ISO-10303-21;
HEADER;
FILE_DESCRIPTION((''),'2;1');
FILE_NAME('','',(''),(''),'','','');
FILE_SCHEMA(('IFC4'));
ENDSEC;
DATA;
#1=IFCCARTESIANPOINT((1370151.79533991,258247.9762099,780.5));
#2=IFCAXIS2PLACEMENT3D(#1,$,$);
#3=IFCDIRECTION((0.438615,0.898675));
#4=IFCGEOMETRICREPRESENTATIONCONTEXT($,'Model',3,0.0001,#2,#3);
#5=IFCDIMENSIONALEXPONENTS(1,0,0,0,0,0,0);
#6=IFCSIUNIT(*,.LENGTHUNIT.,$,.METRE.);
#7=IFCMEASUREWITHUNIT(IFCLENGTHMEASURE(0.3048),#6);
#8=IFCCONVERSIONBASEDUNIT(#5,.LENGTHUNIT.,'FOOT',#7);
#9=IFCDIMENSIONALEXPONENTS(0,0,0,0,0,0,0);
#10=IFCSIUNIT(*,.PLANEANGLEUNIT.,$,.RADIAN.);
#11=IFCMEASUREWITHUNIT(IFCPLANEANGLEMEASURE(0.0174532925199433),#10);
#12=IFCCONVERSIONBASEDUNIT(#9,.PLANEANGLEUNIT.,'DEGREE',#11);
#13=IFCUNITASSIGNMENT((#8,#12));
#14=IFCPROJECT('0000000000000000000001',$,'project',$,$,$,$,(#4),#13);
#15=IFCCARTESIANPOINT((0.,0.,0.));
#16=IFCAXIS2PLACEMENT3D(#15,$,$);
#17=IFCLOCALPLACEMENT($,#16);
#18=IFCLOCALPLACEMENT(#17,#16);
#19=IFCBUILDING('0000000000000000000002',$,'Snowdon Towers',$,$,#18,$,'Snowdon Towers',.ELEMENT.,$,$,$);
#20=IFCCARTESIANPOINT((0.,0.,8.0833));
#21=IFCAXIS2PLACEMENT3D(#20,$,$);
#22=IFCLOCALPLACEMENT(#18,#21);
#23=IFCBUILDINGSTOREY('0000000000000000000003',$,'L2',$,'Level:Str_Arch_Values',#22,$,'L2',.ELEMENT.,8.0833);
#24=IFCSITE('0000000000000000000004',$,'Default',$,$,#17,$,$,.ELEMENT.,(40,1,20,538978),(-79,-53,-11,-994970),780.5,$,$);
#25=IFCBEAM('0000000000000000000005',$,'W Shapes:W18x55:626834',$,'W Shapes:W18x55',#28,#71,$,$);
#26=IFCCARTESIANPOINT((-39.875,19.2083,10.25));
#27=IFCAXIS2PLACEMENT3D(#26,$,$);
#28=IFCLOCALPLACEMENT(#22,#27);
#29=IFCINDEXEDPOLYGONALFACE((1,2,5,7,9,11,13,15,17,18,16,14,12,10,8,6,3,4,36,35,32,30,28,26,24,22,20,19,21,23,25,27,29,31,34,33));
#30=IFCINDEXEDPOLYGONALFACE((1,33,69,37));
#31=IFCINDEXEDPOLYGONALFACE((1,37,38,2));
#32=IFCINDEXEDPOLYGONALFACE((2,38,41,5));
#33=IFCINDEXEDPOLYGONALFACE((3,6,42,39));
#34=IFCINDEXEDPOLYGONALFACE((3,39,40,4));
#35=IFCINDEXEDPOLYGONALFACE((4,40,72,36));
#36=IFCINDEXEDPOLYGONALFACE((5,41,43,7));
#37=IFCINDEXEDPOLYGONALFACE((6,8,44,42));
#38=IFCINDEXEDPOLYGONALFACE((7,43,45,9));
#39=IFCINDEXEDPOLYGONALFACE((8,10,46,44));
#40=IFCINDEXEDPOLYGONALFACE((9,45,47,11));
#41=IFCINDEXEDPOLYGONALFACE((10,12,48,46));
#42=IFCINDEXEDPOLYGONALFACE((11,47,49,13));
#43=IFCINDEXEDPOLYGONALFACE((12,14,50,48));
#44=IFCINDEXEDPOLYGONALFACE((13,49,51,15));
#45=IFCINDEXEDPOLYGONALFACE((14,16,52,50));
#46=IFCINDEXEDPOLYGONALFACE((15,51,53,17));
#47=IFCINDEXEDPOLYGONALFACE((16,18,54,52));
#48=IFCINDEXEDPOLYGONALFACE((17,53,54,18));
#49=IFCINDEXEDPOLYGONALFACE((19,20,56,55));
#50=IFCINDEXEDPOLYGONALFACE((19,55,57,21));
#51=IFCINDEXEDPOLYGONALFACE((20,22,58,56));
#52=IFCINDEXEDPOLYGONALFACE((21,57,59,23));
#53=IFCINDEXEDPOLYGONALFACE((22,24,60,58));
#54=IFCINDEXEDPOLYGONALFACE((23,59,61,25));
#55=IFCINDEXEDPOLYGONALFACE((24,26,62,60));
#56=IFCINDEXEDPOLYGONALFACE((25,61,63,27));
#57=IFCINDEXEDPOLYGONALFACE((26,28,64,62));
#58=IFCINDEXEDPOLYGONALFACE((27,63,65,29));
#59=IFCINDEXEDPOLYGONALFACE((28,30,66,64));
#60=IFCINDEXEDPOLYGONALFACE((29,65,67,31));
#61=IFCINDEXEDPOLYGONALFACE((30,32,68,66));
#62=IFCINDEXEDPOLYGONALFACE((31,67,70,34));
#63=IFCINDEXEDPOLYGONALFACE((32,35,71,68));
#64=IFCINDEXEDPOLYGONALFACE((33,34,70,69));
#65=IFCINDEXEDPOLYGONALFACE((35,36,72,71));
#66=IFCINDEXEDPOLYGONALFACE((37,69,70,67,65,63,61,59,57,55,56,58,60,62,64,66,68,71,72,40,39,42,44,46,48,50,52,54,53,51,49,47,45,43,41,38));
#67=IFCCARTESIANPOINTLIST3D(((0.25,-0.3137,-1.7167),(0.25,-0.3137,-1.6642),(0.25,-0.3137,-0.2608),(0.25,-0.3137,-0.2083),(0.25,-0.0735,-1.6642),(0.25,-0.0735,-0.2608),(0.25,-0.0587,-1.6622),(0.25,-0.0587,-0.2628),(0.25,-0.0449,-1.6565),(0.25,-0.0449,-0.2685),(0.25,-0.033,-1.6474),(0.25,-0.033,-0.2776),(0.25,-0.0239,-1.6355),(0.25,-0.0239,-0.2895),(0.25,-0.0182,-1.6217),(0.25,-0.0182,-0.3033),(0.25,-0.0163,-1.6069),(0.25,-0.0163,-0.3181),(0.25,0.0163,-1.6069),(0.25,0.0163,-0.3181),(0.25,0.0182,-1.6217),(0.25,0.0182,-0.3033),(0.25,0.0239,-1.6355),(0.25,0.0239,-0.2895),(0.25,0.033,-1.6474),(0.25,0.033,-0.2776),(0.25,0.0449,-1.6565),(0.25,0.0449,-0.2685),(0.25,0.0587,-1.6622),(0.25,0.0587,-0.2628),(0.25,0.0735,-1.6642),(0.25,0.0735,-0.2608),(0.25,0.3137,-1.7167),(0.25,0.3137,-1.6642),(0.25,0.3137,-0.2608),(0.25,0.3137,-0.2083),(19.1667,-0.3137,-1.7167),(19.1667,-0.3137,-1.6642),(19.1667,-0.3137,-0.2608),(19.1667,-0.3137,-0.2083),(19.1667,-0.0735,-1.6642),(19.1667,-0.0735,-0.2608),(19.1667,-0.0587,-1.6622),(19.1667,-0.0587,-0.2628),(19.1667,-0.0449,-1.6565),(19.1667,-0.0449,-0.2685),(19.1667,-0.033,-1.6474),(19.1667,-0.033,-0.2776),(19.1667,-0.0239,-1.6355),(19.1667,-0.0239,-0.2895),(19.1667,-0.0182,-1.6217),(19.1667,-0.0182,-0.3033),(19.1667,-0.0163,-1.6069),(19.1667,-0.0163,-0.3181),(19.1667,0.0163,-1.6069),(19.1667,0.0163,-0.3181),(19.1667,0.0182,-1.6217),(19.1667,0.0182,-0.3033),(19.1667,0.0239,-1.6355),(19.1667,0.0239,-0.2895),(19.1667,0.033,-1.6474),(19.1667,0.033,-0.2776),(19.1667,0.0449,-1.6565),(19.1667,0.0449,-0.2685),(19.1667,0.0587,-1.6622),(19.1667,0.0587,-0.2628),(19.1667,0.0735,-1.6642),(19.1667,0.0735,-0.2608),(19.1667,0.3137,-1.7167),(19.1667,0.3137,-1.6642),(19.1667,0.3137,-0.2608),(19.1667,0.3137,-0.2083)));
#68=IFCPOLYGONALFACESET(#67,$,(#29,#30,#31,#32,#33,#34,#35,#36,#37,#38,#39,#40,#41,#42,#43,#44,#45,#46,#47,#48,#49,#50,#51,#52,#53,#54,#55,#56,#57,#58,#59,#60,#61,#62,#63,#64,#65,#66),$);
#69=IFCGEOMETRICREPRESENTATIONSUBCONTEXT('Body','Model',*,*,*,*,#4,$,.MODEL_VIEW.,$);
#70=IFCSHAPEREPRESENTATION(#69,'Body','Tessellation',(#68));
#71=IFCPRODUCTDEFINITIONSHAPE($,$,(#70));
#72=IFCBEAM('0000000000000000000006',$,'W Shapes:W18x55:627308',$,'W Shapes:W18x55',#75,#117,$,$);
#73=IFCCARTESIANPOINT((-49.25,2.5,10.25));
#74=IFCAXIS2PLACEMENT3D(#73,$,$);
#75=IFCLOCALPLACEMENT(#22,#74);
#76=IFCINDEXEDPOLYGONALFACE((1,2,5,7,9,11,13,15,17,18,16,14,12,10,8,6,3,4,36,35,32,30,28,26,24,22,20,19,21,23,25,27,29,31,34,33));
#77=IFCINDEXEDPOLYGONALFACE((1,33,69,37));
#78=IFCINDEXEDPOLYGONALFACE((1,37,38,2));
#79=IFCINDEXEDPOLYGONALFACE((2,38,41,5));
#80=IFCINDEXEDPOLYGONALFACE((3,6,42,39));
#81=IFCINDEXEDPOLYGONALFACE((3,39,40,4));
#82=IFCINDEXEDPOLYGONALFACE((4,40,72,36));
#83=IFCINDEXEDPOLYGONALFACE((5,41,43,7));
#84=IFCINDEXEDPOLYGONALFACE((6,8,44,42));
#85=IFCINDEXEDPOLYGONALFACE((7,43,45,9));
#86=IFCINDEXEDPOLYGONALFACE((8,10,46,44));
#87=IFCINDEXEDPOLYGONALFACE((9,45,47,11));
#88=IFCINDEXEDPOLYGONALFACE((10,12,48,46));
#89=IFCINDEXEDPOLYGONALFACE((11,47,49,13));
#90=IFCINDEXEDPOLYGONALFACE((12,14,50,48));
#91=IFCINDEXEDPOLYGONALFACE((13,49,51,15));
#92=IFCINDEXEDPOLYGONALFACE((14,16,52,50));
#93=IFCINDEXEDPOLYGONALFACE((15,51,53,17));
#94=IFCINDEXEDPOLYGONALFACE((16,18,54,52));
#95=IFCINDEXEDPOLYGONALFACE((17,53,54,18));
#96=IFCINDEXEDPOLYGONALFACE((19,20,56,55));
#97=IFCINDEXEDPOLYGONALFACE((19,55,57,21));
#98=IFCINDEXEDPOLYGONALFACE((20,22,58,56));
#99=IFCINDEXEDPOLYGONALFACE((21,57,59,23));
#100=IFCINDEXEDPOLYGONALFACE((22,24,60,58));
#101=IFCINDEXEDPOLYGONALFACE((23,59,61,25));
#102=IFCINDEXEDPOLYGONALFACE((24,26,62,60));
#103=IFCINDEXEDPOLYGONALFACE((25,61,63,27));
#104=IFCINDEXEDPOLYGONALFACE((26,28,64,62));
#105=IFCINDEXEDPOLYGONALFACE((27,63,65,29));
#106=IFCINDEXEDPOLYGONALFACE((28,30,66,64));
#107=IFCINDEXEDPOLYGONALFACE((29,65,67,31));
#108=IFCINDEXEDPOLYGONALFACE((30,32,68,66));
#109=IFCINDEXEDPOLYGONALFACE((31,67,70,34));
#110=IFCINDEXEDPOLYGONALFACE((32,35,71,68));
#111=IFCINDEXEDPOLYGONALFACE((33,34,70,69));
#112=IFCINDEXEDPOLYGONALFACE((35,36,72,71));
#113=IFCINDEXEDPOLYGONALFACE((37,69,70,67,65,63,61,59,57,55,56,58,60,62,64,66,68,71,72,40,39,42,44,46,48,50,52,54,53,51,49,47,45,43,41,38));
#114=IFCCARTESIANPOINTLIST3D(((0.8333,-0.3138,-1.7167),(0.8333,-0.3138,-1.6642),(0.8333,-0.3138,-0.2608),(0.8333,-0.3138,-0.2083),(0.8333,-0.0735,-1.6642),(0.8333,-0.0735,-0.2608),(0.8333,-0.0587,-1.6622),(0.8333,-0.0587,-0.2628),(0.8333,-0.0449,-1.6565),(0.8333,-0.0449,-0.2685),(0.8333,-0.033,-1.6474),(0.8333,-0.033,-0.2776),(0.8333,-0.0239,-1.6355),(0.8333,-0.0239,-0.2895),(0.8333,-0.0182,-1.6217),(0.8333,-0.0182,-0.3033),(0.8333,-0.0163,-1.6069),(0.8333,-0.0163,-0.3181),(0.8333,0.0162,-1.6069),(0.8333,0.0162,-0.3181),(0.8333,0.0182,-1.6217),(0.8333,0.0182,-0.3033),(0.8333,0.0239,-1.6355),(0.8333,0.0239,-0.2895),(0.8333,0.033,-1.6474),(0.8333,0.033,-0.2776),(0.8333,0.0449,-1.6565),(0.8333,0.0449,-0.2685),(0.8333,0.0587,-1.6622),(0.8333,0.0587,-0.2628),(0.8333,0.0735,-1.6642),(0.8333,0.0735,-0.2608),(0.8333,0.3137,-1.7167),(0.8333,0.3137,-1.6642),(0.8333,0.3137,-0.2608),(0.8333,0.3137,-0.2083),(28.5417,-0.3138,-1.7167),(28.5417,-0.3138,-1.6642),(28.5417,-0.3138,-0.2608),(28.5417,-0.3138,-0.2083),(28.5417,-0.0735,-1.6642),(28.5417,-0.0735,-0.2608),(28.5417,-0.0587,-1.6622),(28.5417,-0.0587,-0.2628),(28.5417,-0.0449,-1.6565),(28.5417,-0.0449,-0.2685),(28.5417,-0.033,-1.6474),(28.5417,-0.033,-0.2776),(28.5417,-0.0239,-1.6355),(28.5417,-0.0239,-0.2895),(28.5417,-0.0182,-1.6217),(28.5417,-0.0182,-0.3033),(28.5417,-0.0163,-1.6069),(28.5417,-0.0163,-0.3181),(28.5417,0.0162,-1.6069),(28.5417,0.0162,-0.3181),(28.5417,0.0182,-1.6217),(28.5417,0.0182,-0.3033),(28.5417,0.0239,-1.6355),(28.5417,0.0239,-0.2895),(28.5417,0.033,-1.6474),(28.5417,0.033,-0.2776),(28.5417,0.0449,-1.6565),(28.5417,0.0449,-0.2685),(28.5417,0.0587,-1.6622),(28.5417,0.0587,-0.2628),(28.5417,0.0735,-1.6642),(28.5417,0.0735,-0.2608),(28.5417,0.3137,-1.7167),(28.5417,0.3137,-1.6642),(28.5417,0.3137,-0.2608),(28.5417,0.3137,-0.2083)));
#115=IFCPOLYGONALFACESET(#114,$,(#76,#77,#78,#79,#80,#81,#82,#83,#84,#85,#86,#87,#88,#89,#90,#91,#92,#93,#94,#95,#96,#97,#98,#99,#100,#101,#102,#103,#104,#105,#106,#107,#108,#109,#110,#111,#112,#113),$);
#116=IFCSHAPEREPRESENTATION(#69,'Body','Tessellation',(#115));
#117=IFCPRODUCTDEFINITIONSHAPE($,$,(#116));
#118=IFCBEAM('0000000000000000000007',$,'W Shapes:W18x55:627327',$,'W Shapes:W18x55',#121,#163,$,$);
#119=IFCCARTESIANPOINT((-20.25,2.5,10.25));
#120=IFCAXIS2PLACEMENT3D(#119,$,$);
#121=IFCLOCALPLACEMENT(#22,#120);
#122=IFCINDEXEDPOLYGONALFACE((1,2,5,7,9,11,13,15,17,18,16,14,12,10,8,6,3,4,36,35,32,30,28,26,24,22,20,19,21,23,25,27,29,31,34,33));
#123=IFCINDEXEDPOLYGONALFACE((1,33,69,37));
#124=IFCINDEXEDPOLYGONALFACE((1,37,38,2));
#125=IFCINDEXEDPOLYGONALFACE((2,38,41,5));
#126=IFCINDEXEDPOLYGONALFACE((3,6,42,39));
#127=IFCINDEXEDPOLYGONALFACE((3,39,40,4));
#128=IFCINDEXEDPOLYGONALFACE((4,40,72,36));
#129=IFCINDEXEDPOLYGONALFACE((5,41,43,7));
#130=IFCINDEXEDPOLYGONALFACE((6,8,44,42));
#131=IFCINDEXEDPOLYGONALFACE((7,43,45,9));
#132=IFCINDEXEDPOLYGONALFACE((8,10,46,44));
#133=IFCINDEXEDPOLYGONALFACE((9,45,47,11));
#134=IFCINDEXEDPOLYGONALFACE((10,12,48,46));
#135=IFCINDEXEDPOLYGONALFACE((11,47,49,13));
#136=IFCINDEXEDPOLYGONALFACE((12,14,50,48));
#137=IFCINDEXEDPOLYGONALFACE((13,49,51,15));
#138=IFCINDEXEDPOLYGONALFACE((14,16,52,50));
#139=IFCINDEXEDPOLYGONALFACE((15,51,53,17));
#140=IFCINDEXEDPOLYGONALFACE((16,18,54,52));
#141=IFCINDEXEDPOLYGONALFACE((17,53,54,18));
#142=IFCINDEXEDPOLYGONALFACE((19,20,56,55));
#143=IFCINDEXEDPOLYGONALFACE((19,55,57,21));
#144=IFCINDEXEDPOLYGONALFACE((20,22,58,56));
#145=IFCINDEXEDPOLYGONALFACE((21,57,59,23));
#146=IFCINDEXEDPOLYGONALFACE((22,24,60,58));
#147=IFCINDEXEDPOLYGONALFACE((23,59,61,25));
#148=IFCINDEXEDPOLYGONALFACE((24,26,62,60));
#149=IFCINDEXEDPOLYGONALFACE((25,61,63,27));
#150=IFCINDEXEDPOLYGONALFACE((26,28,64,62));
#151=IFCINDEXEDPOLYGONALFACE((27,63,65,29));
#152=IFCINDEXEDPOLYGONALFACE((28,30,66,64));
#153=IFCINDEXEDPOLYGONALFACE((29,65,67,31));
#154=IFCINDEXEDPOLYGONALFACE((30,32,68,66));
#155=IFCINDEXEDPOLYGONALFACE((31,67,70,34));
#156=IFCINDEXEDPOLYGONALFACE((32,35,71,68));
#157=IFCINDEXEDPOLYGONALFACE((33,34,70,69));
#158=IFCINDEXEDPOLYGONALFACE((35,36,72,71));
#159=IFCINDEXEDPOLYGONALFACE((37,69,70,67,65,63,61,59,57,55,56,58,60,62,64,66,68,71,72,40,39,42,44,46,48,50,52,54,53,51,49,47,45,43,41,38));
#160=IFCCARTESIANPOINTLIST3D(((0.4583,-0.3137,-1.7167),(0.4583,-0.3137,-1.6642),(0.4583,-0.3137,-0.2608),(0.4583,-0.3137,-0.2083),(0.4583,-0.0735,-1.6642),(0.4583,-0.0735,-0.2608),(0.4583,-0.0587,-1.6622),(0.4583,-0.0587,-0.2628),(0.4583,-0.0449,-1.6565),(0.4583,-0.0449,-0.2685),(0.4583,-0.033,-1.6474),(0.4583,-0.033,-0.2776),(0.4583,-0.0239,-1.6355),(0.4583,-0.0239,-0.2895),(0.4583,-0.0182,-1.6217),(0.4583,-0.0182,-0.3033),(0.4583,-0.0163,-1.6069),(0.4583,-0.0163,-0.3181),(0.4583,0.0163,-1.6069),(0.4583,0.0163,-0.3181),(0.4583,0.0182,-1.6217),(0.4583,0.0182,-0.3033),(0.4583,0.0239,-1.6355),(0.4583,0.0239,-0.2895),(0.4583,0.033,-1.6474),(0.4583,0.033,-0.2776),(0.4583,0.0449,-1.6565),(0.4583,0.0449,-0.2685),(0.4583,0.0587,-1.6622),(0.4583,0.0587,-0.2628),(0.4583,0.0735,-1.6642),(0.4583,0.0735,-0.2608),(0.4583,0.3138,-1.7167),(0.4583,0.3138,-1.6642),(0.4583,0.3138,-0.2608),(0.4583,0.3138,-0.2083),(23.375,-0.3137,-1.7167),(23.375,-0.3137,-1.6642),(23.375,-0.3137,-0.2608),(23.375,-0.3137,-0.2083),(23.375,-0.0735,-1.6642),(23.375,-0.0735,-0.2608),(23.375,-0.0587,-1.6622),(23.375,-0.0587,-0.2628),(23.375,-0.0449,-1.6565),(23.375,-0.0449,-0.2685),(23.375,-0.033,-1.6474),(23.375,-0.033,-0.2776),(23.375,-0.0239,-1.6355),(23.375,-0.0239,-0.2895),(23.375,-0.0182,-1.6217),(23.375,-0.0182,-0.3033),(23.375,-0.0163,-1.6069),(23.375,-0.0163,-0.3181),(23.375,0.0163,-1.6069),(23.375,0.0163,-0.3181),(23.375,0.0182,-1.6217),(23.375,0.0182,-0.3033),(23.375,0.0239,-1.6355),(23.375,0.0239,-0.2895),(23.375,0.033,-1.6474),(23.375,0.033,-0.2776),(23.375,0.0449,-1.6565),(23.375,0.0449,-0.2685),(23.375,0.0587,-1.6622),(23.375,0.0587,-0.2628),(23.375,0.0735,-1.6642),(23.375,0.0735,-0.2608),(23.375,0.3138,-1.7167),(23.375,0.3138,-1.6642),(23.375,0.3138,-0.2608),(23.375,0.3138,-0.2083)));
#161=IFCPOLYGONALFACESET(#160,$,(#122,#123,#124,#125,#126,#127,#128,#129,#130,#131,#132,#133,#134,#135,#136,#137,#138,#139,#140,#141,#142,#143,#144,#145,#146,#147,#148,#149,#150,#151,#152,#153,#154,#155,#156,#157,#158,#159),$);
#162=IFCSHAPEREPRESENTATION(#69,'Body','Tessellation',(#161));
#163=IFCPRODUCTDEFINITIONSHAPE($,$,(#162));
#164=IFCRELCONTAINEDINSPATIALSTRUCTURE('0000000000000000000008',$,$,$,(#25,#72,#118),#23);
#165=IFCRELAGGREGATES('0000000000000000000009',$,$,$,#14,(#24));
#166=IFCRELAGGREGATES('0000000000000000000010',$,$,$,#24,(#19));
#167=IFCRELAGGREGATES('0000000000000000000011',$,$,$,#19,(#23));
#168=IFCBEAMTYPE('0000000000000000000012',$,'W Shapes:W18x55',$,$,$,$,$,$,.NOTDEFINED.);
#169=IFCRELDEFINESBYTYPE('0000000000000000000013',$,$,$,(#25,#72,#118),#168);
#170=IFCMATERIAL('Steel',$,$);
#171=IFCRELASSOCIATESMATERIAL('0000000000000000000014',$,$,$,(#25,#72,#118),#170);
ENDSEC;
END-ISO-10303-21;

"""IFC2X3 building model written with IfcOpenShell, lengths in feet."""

from ifc_helpers import new_model, entity, si_unit, converted_unit, direction, frame, frame_2d, origin, place, context, subcontext, project, spatial, i_section, extrude, material, type_object, element, save


model = new_model("IFC2X3")

# Units and contexts
model_context = context("Model", 3, precision=0.0001, world=frame((1370151.79533991, 258247.9762099, 780.5)), true_north=direction((0.438615, 0.898675)))
body_context = subcontext(model_context, "Body", "Model", "MODEL_VIEW")
ifc_project = project(units=[converted_unit("LENGTHUNIT", "FOOT", entity("IfcLengthMeasure", 0.3048), si_unit("LENGTHUNIT", "METRE"), dimensions=[1, 0, 0, 0, 0, 0, 0]), converted_unit("PLANEANGLEUNIT", "DEGREE", entity("IfcPlaneAngleMeasure", 0.0174532925199433), si_unit("PLANEANGLEUNIT", "RADIAN"), dimensions=[0, 0, 0, 0, 0, 0, 0])], contexts=[model_context])

# Site, building, storey
site_placement = place(None, origin())
site = spatial("IfcSite", under=ifc_project, at=site_placement, Name="Default", CompositionType="ELEMENT", RefLatitude=(40, 1, 20, 538978), RefLongitude=(-79, -53, -11, -994970), RefElevation=780.5)
building_placement = place(site_placement, origin())
building = spatial("IfcBuilding", under=site, at=building_placement, Name="Snowdon Towers", LongName="Snowdon Towers", CompositionType="ELEMENT")
storey_placement = place(building_placement, frame((0.0, 0.0, 8.0833)))
storey = spatial("IfcBuildingStorey", under=building, at=storey_placement, Name="L2", ObjectType="Level:Str_Arch_Values", LongName="L2", CompositionType="ELEMENT", Elevation=8.0833)

# Beams
ifc_material_1 = material(Name="Steel")
beam_type_1 = type_object("IfcBeamType", Name="W Shapes:W18x55", PredefinedType="NOTDEFINED")
beam_1_placement = place(storey_placement, frame((-39.875, 19.2083, 10.25)))
element("IfcBeam", 1, at=beam_1_placement, inside=storey, type_object=beam_type_1, material=ifc_material_1, Name="W Shapes:W18x55:626834", ObjectType="W Shapes:W18x55", context=body_context, shape_type="SweptSolid", body=[
    extrude(i_section(OverallWidth=0.6275, OverallDepth=1.5083, WebThickness=0.0325, FlangeThickness=0.0525, FilletRadius=0.0573, at=frame_2d((0.0, 0.0), x_axis=(0.0, 1.0))), frame((0.25, 0.0, -0.9625), z_axis=(1.0, 0.0, 0.0), x_axis=(0.0, 0.0, -1.0)), (0.0, 0.0, 1.0), 18.9167),
])
beam_2_placement = place(storey_placement, frame((-49.25, 2.5, 10.25)))
element("IfcBeam", 2, at=beam_2_placement, inside=storey, type_object=beam_type_1, material=ifc_material_1, Name="W Shapes:W18x55:627308", ObjectType="W Shapes:W18x55", context=body_context, shape_type="SweptSolid", body=[
    extrude(i_section(OverallWidth=0.6275, OverallDepth=1.5083, WebThickness=0.0325, FlangeThickness=0.0525, FilletRadius=0.0573, at=frame_2d((0.0, 0.0), x_axis=(0.0, 1.0))), frame((0.8333, 0.0, -0.9625), z_axis=(1.0, 0.0, 0.0), x_axis=(0.0, 0.0, -1.0)), (0.0, 0.0, 1.0), 27.7083),
])
beam_3_placement = place(storey_placement, frame((-20.25, 2.5, 10.25)))
element("IfcBeam", 3, at=beam_3_placement, inside=storey, type_object=beam_type_1, material=ifc_material_1, Name="W Shapes:W18x55:627327", ObjectType="W Shapes:W18x55", context=body_context, shape_type="SweptSolid", body=[
    extrude(i_section(OverallWidth=0.6275, OverallDepth=1.5083, WebThickness=0.0325, FlangeThickness=0.0525, FilletRadius=0.0573, at=frame_2d((0.0, 0.0), x_axis=(0.0, 1.0))), frame((0.4583, 0.0, -0.9625), z_axis=(1.0, 0.0, 0.0), x_axis=(0.0, 0.0, -1.0)), (0.0, 0.0, 1.0), 22.9167),
])

save(model, "model.ifc")
